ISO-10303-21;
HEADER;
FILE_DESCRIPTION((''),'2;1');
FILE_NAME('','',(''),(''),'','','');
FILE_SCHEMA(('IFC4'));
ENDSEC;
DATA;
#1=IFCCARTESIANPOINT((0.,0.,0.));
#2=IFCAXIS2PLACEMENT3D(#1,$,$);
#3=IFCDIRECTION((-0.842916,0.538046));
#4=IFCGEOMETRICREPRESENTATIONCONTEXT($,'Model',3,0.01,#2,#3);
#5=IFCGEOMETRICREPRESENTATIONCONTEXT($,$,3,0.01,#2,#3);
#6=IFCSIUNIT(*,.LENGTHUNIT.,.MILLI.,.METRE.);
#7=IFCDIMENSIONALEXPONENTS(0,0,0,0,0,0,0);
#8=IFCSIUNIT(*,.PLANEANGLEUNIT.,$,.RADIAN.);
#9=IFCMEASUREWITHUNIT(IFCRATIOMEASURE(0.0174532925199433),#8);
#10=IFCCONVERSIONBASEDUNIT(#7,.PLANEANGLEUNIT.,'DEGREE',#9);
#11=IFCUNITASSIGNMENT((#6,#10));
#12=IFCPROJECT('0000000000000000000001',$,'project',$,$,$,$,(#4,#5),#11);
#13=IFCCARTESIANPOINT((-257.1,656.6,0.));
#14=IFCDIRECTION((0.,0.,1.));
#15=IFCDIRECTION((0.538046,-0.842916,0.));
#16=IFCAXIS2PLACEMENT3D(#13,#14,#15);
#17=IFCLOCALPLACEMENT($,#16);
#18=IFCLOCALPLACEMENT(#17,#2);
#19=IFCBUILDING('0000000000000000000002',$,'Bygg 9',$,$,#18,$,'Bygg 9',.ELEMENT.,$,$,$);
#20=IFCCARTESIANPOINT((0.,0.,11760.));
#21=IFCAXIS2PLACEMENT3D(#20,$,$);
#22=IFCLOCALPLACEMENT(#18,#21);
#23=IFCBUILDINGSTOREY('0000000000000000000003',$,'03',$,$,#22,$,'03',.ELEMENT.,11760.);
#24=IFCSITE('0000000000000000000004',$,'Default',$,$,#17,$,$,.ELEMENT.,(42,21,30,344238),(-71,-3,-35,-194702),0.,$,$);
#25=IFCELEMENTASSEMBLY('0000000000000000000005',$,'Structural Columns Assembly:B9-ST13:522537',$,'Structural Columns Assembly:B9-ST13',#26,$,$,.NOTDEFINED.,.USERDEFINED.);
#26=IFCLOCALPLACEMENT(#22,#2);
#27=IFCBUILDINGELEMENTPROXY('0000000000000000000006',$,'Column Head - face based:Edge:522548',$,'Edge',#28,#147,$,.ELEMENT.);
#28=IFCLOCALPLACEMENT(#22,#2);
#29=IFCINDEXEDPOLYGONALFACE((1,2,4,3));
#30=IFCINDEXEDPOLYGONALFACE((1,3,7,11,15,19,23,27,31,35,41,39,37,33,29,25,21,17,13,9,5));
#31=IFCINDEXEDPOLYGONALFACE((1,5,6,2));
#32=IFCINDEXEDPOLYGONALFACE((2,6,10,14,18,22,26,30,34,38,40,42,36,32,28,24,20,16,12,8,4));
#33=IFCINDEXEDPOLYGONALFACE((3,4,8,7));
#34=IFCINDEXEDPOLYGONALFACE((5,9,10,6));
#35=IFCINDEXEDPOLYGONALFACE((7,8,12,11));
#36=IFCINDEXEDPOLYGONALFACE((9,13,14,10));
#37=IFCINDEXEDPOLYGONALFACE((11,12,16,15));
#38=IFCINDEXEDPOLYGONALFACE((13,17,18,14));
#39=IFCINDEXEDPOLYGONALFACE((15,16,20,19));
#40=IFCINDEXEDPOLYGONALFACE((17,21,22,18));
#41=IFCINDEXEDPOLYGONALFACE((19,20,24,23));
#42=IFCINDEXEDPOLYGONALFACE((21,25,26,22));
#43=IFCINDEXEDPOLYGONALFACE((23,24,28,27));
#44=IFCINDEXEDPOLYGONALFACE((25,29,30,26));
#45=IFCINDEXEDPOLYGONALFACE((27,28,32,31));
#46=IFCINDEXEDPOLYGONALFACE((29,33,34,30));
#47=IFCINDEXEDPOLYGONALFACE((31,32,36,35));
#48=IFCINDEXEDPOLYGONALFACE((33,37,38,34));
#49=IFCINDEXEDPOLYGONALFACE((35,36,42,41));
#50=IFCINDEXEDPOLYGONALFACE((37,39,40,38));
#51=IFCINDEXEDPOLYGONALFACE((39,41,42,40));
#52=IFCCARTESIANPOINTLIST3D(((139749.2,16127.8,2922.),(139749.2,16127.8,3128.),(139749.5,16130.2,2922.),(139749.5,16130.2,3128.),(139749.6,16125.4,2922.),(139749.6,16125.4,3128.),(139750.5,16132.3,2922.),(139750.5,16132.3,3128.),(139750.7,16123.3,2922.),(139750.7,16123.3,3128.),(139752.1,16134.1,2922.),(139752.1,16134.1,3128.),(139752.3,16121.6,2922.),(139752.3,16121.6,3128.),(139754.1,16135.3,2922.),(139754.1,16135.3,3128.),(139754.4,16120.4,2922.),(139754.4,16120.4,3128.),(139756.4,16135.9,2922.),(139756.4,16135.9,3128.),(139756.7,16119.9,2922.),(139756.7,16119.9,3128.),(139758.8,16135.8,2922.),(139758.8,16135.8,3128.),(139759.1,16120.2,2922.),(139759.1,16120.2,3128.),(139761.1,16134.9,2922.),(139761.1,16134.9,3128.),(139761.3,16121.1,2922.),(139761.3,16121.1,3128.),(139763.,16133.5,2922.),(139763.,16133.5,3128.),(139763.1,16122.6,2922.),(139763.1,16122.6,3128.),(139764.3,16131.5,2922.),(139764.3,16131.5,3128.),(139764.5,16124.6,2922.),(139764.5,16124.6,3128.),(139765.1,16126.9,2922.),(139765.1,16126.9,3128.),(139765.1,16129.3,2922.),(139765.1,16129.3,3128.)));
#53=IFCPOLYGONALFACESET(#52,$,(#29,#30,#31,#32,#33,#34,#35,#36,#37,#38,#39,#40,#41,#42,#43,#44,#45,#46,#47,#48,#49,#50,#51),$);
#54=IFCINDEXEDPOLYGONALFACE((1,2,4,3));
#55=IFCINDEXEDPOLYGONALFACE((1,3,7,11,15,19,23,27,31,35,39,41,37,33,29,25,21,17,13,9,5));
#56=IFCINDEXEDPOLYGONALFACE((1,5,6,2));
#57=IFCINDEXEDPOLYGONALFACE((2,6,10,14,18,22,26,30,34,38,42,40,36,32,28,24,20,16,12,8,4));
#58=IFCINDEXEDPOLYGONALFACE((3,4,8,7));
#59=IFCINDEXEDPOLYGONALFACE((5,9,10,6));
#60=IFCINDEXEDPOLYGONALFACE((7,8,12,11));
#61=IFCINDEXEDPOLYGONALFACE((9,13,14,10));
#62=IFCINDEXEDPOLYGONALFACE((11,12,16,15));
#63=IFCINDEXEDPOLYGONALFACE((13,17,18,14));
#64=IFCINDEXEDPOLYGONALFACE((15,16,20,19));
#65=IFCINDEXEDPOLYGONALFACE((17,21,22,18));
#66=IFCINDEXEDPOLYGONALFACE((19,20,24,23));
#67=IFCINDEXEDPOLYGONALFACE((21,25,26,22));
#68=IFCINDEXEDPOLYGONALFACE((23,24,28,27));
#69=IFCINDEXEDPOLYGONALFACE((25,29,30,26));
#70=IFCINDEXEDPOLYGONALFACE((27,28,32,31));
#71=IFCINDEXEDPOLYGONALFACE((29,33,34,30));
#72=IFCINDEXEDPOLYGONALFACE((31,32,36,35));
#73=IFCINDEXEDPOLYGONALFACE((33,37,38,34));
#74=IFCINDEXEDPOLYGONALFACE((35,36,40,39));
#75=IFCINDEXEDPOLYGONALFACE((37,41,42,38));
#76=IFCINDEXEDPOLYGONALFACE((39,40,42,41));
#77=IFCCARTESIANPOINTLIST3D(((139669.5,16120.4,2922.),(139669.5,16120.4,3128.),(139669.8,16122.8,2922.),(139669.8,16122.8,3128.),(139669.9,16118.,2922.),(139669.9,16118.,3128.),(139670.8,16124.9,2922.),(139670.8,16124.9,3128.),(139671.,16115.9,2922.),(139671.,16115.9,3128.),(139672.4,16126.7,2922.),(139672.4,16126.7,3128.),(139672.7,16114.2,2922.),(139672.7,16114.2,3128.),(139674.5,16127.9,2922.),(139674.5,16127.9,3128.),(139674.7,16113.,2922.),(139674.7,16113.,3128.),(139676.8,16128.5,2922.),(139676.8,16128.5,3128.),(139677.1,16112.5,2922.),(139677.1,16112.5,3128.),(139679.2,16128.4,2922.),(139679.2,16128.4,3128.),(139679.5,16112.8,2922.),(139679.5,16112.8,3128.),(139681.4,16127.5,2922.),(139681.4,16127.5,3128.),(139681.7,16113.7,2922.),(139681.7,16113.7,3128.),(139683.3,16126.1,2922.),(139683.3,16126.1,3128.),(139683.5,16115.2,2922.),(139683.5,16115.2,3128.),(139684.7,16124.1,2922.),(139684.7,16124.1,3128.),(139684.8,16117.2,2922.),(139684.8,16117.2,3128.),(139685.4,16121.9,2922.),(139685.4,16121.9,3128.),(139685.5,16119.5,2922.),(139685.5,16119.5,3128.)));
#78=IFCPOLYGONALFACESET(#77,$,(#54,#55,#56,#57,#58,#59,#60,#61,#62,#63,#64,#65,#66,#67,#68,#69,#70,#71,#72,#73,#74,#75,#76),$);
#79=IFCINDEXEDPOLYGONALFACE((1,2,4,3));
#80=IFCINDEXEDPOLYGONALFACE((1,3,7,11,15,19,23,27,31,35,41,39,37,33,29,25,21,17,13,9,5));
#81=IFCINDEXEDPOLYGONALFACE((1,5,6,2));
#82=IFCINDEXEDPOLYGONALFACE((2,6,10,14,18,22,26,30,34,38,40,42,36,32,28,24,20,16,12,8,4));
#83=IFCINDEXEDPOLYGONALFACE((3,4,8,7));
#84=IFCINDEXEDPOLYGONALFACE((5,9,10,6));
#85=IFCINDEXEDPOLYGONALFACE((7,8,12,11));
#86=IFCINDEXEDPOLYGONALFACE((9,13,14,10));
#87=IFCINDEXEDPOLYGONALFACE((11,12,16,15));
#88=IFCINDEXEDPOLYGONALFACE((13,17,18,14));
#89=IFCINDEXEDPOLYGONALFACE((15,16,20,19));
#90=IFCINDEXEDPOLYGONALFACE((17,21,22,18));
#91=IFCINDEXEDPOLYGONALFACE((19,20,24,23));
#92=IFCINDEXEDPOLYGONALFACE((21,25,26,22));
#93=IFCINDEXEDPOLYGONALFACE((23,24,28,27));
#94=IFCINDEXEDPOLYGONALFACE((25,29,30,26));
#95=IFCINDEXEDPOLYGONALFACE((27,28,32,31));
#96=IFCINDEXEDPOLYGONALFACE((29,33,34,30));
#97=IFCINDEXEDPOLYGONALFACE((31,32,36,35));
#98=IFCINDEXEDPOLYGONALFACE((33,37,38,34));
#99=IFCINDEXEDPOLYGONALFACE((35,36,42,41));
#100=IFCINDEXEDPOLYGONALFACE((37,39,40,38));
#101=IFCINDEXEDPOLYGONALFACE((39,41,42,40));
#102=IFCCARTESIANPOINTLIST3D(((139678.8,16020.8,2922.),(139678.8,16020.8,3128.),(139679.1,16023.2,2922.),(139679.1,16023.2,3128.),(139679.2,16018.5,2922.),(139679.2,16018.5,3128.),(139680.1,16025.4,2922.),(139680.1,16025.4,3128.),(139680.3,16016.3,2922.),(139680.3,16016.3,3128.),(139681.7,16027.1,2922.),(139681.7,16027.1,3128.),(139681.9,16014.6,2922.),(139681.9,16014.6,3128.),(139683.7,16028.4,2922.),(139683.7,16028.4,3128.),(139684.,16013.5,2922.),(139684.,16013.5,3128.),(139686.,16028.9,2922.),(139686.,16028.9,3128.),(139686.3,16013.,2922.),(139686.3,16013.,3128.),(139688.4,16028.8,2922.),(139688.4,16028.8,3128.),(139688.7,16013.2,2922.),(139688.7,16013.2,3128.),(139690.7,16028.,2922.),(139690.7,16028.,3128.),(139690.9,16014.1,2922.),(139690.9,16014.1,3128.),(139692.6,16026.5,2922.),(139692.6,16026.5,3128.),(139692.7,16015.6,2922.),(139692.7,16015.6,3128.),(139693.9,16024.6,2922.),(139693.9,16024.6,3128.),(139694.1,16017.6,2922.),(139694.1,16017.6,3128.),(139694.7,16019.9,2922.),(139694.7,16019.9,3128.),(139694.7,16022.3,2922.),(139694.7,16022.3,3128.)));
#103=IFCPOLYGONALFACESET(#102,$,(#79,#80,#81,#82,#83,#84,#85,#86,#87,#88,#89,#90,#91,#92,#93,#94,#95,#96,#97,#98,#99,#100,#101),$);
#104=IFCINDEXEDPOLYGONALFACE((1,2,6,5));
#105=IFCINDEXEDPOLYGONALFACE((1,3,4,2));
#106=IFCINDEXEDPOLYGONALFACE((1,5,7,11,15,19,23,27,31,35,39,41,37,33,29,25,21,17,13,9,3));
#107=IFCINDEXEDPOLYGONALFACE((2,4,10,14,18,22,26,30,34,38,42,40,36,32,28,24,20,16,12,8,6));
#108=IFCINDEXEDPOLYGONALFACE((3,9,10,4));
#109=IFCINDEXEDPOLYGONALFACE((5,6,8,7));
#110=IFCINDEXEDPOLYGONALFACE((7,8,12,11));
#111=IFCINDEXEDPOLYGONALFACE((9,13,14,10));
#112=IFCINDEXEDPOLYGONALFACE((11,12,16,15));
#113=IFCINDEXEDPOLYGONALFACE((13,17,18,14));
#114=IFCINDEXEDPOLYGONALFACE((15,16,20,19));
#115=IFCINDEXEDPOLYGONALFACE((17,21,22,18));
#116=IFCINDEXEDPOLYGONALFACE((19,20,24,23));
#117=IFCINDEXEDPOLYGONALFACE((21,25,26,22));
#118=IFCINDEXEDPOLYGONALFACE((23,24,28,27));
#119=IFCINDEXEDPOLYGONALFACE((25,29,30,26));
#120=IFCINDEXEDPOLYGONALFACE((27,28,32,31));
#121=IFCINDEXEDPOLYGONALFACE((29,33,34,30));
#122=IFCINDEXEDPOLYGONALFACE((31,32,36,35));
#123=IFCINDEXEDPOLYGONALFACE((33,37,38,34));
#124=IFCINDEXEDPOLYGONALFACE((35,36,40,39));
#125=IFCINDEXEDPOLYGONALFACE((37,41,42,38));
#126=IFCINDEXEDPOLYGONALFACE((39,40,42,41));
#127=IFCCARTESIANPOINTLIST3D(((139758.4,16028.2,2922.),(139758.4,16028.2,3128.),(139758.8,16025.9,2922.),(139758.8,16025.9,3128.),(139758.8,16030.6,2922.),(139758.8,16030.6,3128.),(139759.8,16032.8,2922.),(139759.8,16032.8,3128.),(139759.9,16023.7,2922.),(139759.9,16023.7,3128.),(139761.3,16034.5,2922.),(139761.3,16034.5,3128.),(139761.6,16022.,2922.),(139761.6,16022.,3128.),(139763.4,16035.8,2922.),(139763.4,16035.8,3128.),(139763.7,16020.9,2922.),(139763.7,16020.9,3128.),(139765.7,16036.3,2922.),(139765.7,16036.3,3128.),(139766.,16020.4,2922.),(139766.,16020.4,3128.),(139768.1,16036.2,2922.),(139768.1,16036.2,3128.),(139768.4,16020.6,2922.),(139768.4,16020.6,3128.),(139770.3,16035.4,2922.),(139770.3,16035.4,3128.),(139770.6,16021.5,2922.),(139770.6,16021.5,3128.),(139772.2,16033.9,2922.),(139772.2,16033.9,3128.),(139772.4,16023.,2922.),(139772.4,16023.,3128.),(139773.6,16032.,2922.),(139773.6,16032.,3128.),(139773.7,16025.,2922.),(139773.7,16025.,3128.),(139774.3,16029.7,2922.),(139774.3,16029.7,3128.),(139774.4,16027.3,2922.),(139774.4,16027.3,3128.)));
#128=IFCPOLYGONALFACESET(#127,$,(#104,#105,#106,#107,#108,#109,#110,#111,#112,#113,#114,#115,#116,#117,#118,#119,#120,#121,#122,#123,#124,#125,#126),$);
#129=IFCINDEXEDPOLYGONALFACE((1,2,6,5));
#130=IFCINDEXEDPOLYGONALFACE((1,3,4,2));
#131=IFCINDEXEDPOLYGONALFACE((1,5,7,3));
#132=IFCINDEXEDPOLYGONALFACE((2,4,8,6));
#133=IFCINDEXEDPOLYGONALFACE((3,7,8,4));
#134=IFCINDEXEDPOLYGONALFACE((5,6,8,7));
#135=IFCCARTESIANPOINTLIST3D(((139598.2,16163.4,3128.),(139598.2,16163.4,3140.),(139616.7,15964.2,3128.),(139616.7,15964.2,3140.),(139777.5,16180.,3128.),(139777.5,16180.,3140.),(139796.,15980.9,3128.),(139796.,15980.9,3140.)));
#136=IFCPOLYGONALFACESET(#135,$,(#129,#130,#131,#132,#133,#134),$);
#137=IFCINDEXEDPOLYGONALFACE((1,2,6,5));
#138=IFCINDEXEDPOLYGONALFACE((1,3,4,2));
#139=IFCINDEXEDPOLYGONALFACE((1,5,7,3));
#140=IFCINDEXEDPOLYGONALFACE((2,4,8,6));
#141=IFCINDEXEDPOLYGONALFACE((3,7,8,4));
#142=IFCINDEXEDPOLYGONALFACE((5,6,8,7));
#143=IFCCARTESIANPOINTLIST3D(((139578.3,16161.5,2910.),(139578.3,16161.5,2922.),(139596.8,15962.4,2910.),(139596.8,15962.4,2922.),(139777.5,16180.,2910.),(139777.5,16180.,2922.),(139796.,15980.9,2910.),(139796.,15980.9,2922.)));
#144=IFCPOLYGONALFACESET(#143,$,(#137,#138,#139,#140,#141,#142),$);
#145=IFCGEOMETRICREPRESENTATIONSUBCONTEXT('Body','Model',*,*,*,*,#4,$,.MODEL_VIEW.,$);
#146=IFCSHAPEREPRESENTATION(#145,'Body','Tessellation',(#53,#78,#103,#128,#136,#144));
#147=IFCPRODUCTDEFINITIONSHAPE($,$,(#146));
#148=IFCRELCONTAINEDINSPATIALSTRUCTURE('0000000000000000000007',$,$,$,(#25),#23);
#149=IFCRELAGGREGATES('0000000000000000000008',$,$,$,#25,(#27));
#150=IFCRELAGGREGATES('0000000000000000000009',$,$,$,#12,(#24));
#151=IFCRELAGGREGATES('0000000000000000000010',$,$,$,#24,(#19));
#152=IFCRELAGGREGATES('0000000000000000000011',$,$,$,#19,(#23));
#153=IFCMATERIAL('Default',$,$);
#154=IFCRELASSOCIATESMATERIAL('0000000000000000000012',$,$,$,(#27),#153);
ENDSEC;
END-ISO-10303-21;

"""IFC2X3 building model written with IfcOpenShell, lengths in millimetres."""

from ifc_helpers import new_model, entity, si_unit, converted_unit, direction, frame, frame_2d, origin, origin_2d_with_axis, place, context, subcontext, project, spatial, rectangle, circle, extrude, source, transform, mapped, material, element, aggregate, save


model = new_model("IFC2X3")

# Units and contexts
model_context = context("Model", 3, precision=0.01, world=origin(), true_north=direction((-0.842916, 0.538046)))
context_of_model = context(None, 3, precision=0.01, world=origin(), true_north=direction((-0.842916, 0.538046)))
body_context = subcontext(model_context, "Body", "Model", "MODEL_VIEW")
ifc_project = project(units=[si_unit("LENGTHUNIT", "METRE", prefix="MILLI"), converted_unit("PLANEANGLEUNIT", "DEGREE", entity("IfcRatioMeasure", 0.0174532925199433), si_unit("PLANEANGLEUNIT", "RADIAN"), dimensions=[0, 0, 0, 0, 0, 0, 0])], contexts=[model_context, context_of_model])

# Site, building, storey
site_placement = place(None, frame((-257.1, 656.6, 0.0), z_axis=(0.0, 0.0, 1.0), x_axis=(0.538046, -0.842916, 0.0)))
site = spatial("IfcSite", under=ifc_project, at=site_placement, Name="Default", CompositionType="ELEMENT", RefLatitude=(42, 21, 30, 344238), RefLongitude=(-71, -3, -35, -194702), RefElevation=0.0)
building_placement = place(site_placement, origin())
building = spatial("IfcBuilding", under=site, at=building_placement, Name="Bygg 9", LongName="Bygg 9", CompositionType="ELEMENT")
storey_placement = place(building_placement, frame((0.0, 0.0, 11760.0)))
storey = spatial("IfcBuildingStorey", under=building, at=storey_placement, Name="03", LongName="03", CompositionType="ELEMENT", Elevation=11760.0)

# Shared definitions
ifc_material_1 = material(Name="Default")

# Element assembly, building element proxy
shared_shape_1 = source(origin(), body_context, "Body", "SweptSolid", [
    extrude(circle(Radius=8.0, at=frame_2d((0.0, 0.0), x_axis=(1.0, 0.0))), frame((50.0, -135.0, 12.0)), (0.0, 0.0, 1.0), 206.0),
    extrude(circle(Radius=8.0, at=frame_2d((0.0, 0.0), x_axis=(1.0, 0.0))), frame((50.0, -55.0, 12.0)), (0.0, 0.0, 1.0), 206.0),
    extrude(circle(Radius=8.0, at=frame_2d((0.0, 0.0), x_axis=(1.0, 0.0))), frame((-50.0, -55.0, 12.0)), (0.0, 0.0, 1.0), 206.0),
    extrude(circle(Radius=8.0, at=frame_2d((0.0, 0.0), x_axis=(1.0, 0.0))), frame((-50.0, -135.0, 12.0)), (0.0, 0.0, 1.0), 206.0),
    extrude(rectangle(XDim=200.0, YDim=180.0, at=origin_2d_with_axis()), frame((0.0, -70.0, 218.0), z_axis=(0.0, 0.0, 1.0), x_axis=(-1.0, 0.0, 0.0)), (0.0, 0.0, 1.0), 12.0),
    extrude(rectangle(XDim=200.0, YDim=200.0, at=origin_2d_with_axis()), frame((0.0, -60.0, 0.0), z_axis=(0.0, 0.0, 1.0), x_axis=(0.0, 1.0, 0.0)), (0.0, 0.0, 1.0), 12.0),
])
assembly_1_placement = place(storey_placement, origin())
assembly_1 = element("IfcElementAssembly", 1, at=assembly_1_placement, inside=storey, Name="Structural Columns Assembly:B9-ST13:522537", ObjectType="Structural Columns Assembly:B9-ST13", AssemblyPlace="NOTDEFINED", PredefinedType="USERDEFINED")
proxy_1_placement = place(assembly_1_placement, frame((139627.4, 16065.7, 2910.0), z_axis=(0.0, 0.0, 1.0), x_axis=(-0.092535, 0.995709, 0.0)))
proxy_1 = element("IfcBuildingElementProxy", 2, at=proxy_1_placement, material=ifc_material_1, Name="Column Head - face based:Edge:522548", ObjectType="Edge", CompositionType="ELEMENT", context=body_context, shape_type="MappedRepresentation", body=[
    mapped(shared_shape_1, transform((0.0, 0.0, 0.0), scale=1.0)),
])
aggregate(assembly_1, [proxy_1])

save(model, "model.ifc")
